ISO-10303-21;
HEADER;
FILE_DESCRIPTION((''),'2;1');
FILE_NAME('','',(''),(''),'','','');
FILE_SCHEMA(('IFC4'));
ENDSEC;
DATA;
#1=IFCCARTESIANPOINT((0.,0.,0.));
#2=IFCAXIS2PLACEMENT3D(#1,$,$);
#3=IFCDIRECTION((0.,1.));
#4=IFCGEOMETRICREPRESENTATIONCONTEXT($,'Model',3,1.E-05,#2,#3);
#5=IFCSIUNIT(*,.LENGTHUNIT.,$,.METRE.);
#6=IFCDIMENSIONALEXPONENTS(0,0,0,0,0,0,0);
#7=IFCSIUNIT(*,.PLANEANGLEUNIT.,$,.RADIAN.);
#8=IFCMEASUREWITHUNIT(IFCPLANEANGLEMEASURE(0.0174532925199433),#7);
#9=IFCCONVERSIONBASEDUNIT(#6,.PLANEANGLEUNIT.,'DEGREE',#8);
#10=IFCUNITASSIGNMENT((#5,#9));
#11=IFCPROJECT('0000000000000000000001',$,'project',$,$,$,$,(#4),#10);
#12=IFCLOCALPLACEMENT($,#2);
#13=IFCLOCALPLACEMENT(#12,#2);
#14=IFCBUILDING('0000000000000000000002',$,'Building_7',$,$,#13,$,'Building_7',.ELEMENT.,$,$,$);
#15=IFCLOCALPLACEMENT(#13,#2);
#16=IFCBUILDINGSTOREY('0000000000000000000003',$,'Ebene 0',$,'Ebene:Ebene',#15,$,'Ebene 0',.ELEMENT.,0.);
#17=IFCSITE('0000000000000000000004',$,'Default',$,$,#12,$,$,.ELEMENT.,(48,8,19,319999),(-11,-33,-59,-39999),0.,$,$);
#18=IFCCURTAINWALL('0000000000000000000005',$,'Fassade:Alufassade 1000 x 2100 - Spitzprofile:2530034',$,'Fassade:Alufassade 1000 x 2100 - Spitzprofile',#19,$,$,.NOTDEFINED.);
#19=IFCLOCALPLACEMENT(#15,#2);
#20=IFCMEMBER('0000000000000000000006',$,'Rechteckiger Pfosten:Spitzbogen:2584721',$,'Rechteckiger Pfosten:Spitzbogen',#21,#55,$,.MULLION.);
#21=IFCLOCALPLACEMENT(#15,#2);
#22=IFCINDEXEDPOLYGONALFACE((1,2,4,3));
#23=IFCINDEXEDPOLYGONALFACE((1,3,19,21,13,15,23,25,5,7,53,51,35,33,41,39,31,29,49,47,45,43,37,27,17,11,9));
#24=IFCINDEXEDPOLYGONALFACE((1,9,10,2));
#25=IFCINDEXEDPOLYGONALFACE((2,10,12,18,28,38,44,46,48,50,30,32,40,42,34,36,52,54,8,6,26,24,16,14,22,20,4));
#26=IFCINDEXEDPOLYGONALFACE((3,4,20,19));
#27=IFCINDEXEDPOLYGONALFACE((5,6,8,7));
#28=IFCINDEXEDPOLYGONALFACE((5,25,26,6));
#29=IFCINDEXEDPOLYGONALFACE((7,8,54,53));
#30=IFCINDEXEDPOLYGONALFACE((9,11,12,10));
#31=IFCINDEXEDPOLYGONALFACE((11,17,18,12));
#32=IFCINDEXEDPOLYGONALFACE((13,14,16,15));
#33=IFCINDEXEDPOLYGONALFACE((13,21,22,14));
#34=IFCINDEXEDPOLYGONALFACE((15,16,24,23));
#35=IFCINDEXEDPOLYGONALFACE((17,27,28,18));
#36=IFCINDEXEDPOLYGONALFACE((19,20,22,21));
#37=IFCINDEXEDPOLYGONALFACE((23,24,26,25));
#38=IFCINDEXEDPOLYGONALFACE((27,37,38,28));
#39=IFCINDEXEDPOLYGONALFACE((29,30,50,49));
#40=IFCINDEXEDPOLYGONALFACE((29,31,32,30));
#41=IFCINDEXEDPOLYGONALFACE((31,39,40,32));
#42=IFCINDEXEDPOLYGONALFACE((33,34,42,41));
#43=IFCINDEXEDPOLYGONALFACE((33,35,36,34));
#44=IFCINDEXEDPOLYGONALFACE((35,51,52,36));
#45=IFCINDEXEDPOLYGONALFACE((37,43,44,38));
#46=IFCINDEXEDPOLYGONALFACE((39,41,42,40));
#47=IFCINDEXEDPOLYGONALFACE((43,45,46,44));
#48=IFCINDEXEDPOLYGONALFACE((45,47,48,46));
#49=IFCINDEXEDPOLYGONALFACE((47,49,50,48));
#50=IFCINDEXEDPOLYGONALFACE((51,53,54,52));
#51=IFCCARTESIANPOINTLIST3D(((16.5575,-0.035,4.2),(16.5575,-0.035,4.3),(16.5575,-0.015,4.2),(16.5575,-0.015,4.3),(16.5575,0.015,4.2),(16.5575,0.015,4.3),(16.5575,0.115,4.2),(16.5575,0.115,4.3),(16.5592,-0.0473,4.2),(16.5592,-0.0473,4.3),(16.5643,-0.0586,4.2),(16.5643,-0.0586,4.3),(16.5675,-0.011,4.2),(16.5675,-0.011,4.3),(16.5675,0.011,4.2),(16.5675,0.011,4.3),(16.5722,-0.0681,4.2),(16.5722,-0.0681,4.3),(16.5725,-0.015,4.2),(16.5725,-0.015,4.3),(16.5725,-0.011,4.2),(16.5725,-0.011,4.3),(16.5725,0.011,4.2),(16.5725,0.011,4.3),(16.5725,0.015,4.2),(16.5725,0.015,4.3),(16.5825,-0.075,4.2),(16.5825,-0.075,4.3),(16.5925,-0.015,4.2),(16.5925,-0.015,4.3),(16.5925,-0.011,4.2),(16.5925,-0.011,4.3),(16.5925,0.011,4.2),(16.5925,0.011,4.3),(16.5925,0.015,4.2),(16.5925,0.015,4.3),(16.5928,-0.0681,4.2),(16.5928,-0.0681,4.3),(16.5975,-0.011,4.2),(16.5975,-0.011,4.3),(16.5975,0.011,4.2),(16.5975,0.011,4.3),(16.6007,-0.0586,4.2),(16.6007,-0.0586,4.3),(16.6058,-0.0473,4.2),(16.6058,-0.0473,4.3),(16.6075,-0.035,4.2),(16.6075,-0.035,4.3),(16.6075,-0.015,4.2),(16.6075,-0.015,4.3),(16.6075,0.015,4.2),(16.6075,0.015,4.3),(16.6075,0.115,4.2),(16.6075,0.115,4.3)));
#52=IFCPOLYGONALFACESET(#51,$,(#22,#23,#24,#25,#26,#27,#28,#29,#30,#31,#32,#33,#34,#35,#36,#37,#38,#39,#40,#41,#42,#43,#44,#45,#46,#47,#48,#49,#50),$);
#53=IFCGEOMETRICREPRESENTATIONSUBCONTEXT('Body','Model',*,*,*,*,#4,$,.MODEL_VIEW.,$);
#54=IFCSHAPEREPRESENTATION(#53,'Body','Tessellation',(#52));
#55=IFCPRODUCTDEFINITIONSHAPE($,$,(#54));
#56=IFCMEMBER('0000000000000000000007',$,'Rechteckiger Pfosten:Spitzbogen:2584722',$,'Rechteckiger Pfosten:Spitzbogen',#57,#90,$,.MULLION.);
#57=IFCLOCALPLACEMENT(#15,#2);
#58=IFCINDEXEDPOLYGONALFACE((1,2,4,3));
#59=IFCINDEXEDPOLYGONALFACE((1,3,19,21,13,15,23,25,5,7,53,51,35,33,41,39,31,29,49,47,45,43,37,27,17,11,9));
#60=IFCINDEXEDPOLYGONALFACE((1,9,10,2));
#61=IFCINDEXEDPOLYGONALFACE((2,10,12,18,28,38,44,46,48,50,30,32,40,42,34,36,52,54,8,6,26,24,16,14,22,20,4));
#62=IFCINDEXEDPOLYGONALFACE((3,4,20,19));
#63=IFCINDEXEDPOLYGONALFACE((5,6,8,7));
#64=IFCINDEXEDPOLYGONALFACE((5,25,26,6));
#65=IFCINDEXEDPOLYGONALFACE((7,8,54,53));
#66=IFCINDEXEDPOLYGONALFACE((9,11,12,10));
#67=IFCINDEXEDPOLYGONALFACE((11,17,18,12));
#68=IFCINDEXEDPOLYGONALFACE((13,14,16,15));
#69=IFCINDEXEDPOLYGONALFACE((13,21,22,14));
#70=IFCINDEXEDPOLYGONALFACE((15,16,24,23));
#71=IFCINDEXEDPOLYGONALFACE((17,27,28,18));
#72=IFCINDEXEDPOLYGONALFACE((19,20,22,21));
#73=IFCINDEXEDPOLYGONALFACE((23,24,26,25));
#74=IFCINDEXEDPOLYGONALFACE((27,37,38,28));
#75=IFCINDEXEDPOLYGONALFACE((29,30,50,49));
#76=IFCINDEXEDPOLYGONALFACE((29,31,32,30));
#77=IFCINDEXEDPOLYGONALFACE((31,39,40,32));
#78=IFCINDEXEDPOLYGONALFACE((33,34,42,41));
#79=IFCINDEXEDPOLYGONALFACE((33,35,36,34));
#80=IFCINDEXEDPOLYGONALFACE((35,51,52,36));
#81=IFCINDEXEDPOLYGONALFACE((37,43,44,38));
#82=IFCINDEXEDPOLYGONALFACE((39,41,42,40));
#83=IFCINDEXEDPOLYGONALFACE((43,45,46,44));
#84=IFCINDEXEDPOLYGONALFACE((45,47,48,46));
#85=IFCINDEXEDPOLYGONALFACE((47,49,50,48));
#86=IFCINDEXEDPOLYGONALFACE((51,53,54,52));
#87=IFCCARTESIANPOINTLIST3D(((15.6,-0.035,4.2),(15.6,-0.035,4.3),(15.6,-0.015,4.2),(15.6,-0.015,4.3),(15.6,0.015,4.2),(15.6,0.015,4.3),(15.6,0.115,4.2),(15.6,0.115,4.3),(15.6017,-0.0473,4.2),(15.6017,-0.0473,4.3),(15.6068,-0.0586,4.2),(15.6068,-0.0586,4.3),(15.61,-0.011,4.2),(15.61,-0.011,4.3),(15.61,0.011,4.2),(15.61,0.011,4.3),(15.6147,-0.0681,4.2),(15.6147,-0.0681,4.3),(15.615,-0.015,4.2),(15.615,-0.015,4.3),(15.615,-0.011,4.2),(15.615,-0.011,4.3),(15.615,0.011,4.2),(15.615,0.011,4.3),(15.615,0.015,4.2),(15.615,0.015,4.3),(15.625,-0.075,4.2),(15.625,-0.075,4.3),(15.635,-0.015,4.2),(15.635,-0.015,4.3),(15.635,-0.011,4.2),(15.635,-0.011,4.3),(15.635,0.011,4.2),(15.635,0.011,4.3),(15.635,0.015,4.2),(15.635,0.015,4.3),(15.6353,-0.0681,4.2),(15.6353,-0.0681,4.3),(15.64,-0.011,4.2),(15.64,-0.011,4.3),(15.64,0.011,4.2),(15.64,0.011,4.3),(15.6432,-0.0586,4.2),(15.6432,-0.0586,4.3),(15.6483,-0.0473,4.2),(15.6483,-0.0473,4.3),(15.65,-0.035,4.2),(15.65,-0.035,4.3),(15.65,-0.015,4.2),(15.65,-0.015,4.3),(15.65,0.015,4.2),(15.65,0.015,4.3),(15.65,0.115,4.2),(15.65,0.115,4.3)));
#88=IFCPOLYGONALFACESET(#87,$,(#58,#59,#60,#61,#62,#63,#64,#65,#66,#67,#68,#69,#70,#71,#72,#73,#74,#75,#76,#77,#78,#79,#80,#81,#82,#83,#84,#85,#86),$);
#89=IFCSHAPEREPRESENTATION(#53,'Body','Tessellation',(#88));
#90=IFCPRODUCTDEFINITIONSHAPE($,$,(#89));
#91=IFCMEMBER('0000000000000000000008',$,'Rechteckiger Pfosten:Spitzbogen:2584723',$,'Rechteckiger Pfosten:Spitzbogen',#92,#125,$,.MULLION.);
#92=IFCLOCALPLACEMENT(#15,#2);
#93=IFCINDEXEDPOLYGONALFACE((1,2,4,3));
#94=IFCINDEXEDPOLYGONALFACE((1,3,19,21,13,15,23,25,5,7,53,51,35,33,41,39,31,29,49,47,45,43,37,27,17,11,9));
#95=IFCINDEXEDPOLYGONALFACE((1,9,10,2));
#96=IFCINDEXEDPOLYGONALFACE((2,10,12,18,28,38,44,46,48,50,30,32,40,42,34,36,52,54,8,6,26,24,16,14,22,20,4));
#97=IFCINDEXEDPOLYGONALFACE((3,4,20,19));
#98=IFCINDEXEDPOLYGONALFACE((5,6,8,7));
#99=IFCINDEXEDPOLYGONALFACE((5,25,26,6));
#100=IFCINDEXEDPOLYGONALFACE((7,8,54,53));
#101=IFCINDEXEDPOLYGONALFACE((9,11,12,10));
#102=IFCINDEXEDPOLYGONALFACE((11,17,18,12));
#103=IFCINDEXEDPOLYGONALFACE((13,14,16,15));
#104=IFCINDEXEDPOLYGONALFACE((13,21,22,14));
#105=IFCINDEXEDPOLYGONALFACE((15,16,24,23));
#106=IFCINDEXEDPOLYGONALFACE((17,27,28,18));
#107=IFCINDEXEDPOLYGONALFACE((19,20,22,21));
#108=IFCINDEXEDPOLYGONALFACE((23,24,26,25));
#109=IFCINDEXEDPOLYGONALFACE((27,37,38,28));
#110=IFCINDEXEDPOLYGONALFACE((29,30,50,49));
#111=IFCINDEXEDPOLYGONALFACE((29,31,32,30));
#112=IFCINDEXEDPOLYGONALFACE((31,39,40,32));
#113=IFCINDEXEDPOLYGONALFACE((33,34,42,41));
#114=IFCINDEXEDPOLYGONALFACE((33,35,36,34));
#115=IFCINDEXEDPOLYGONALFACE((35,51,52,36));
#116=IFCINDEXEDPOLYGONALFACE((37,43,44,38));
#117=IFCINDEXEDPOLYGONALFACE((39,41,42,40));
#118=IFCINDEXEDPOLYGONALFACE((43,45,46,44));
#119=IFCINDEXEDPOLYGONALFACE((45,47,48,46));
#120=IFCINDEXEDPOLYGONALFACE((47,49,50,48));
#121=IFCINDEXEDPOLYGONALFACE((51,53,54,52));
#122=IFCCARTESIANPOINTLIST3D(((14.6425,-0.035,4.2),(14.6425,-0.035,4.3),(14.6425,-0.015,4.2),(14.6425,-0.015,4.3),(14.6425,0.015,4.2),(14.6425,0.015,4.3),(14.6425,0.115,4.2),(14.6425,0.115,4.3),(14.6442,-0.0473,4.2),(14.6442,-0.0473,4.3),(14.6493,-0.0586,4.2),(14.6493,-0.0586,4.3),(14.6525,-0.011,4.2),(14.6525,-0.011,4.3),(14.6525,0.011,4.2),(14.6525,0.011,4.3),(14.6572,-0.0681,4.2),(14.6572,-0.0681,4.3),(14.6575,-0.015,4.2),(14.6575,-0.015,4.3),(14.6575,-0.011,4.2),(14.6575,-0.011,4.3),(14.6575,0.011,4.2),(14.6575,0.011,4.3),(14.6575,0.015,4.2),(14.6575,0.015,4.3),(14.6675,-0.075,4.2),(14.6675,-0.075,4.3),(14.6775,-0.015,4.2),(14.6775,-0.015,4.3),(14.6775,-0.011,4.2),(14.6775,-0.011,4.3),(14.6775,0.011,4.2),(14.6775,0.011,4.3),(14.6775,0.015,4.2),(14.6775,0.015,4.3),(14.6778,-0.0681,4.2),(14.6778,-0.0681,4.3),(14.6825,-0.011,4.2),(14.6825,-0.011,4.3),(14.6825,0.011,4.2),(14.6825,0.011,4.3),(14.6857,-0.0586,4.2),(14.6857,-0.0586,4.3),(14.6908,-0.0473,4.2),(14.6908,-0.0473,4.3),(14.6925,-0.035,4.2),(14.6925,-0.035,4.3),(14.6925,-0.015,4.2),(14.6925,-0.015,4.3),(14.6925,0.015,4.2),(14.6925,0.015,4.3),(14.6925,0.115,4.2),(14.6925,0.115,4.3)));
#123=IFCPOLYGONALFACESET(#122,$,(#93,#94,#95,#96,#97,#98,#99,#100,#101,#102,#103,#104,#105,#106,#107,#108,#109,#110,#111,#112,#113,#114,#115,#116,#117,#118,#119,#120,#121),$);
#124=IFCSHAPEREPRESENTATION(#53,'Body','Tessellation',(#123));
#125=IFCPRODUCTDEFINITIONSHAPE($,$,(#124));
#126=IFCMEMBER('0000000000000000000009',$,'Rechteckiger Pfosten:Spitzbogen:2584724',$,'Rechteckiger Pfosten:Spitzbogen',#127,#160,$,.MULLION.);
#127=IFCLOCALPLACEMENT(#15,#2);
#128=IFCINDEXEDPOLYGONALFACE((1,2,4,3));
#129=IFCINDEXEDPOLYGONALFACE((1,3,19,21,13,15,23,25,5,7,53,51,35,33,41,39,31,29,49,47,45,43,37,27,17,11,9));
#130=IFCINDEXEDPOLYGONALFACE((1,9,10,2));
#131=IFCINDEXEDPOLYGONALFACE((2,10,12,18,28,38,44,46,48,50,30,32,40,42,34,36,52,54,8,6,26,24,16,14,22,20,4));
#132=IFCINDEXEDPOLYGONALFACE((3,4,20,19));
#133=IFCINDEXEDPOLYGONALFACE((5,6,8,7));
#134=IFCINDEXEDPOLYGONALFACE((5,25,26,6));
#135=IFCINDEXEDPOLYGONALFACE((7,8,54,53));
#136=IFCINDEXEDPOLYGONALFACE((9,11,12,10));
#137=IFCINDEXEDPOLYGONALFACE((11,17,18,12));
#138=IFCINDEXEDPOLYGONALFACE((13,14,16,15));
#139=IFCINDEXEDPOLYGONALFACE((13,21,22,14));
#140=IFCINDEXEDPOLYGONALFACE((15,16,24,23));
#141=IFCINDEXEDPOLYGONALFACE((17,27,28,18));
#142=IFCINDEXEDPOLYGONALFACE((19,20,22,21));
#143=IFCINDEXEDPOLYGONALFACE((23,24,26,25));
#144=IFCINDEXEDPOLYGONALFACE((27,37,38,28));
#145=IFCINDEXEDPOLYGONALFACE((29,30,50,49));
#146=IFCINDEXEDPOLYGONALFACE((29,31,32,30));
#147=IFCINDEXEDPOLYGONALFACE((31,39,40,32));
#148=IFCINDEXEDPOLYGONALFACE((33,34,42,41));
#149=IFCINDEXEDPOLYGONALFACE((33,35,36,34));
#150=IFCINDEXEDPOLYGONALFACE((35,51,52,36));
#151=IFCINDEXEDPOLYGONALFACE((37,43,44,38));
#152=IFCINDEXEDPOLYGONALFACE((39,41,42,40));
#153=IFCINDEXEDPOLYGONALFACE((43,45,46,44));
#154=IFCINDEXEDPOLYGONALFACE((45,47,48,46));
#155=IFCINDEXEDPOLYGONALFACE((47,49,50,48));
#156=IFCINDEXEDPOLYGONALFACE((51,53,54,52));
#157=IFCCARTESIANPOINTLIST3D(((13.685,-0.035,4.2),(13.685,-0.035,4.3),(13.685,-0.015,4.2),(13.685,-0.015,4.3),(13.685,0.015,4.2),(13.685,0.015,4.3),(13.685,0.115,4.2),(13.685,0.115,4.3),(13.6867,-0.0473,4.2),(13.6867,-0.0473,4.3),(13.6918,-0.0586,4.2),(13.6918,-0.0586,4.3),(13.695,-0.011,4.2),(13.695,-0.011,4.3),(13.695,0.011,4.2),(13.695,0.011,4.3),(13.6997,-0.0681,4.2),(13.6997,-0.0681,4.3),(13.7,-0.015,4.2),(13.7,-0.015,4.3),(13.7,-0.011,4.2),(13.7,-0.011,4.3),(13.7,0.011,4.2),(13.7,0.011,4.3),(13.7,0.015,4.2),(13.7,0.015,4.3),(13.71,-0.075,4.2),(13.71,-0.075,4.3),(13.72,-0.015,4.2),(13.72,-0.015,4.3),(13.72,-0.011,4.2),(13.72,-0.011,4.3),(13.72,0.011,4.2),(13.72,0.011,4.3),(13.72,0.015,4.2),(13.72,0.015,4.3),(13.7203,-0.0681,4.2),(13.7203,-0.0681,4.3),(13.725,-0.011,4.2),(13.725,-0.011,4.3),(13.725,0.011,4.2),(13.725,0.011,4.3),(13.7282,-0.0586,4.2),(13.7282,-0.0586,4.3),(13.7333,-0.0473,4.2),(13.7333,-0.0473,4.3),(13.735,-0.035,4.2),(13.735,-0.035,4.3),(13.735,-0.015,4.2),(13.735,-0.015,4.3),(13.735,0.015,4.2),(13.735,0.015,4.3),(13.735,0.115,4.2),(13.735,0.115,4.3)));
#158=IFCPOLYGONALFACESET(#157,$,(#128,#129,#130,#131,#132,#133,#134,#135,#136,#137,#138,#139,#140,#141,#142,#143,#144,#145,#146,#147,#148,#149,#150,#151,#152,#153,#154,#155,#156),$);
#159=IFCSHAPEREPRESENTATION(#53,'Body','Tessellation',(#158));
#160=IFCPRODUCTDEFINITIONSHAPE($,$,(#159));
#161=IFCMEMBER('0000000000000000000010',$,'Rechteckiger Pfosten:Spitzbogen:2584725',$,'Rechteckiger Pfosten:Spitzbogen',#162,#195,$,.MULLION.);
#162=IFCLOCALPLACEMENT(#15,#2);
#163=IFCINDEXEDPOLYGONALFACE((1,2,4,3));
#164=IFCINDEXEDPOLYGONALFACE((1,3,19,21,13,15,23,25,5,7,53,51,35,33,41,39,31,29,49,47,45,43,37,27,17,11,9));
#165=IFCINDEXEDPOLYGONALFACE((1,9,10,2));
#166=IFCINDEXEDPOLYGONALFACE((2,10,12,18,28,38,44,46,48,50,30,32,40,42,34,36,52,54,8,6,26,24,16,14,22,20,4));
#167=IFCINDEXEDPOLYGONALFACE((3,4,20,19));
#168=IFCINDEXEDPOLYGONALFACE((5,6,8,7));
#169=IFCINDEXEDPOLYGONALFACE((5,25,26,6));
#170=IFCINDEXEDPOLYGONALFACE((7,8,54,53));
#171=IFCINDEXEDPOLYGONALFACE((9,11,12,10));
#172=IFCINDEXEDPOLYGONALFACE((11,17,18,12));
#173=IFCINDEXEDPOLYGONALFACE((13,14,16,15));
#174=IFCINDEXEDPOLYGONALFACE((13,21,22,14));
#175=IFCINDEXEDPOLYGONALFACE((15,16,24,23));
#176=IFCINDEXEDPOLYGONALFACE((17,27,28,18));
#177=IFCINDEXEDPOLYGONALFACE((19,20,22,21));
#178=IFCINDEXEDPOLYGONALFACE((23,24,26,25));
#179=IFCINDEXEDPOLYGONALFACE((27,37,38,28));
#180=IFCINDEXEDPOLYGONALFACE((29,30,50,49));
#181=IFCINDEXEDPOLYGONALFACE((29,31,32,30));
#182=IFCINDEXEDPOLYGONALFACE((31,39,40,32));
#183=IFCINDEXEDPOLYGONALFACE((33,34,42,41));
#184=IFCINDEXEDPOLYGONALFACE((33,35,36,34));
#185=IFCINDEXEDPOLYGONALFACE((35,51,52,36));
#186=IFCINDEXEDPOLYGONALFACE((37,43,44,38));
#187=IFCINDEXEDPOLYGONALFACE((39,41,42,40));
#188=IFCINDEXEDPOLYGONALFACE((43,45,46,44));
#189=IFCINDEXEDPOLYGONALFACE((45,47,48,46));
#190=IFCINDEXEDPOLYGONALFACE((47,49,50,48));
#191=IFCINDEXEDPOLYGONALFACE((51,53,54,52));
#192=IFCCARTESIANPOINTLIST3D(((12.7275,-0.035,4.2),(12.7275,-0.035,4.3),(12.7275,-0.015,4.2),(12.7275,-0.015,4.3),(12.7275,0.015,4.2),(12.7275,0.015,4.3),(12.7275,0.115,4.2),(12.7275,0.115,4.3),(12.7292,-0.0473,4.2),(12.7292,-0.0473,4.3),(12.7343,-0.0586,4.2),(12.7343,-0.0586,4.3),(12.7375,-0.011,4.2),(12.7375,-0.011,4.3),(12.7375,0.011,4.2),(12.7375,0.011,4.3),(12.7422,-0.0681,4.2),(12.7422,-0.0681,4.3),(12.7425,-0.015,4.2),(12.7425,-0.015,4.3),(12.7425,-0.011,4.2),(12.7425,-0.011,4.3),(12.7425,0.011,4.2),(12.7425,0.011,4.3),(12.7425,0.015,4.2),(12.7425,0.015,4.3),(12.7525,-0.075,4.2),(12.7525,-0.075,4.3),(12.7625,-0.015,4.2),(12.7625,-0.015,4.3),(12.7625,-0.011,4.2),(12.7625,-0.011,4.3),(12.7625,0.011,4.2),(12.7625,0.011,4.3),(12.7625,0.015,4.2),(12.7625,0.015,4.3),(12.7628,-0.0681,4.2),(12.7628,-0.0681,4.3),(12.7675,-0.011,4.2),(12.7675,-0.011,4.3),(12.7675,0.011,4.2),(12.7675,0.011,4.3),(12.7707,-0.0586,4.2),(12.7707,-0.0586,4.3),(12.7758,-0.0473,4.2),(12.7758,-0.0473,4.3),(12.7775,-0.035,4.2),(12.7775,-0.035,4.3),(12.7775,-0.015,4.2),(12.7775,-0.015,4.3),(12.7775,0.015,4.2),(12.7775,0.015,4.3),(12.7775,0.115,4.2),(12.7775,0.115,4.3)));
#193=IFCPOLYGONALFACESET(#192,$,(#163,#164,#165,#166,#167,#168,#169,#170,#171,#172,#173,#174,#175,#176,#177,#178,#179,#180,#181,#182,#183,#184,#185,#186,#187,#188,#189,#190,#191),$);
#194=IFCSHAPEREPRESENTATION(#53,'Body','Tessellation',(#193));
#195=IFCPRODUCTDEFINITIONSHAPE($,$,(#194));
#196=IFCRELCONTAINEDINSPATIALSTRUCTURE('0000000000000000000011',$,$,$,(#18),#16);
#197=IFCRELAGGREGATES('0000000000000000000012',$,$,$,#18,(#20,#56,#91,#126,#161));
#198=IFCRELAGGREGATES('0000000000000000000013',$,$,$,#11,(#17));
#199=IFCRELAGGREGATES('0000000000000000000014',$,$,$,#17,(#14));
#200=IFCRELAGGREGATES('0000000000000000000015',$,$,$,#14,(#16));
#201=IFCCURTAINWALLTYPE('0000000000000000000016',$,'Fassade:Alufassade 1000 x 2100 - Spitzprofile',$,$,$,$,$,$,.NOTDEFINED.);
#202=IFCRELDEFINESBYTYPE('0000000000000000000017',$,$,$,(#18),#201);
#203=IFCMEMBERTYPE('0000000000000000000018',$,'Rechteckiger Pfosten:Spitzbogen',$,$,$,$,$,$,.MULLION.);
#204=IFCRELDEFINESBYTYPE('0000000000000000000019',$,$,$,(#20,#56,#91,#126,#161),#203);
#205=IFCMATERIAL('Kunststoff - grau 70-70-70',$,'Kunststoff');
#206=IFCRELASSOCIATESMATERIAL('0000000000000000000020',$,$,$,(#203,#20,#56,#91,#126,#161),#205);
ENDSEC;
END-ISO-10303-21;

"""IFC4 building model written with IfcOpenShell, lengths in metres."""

from ifc_helpers import new_model, entity, si_unit, converted_unit, direction, frame, origin, place, context, subcontext, project, spatial, line, arc, indexed_curve, outline, extrude, source, transform, mapped, material, type_object, type_shapes, element, aggregate, save


model = new_model("IFC4")

# Units and contexts
model_context = context("Model", 3, precision=1e-05, world=origin(), true_north=direction((0.0, 1.0)))
body_context = subcontext(model_context, "Body", "Model", "MODEL_VIEW")
ifc_project = project(units=[si_unit("LENGTHUNIT", "METRE"), converted_unit("PLANEANGLEUNIT", "DEGREE", entity("IfcPlaneAngleMeasure", 0.0174532925199433), si_unit("PLANEANGLEUNIT", "RADIAN"), dimensions=[0, 0, 0, 0, 0, 0, 0])], contexts=[model_context])

# Site, building, storey
site_placement = place(None, origin())
site = spatial("IfcSite", under=ifc_project, at=site_placement, Name="Default", CompositionType="ELEMENT", RefLatitude=(48, 8, 19, 319999), RefLongitude=(-11, -33, -59, -39999), RefElevation=0.0)
building_placement = place(site_placement, origin())
building = spatial("IfcBuilding", under=site, at=building_placement, Name="Building_7", LongName="Building_7", CompositionType="ELEMENT")
storey_placement = place(building_placement, origin())
storey = spatial("IfcBuildingStorey", under=building, at=storey_placement, Name="Ebene 0", ObjectType="Ebene:Ebene", LongName="Ebene 0", CompositionType="ELEMENT", Elevation=0.0)

# Curtain wall, members
curtain_wall_type = type_object("IfcCurtainWallType", Name="Fassade:Alufassade 1000 x 2100 - Spitzprofile", PredefinedType="NOTDEFINED")
curtain_wall_placement = place(storey_placement, origin())
curtain_wall = element("IfcCurtainWall", 1, at=curtain_wall_placement, inside=storey, type_object=curtain_wall_type, Name="Fassade:Alufassade 1000 x 2100 - Spitzprofile:2530034", ObjectType="Fassade:Alufassade 1000 x 2100 - Spitzprofile", PredefinedType="NOTDEFINED")
ifc_material = material(Name="Kunststoff - grau 70-70-70", Category="Kunststoff")
member_type_1 = type_object("IfcMemberType", Name="Rechteckiger Pfosten:Spitzbogen", PredefinedType="MULLION", material=ifc_material)
shared_shape_1 = source(origin(), body_context, "Body", "SweptSolid", [
    extrude(outline(indexed_curve([(-0.111, -0.025), (-0.011, -0.025), (-0.011, -0.01), (-0.007, -0.01), (-0.007, -0.015), (0.015, -0.015), (0.015, -0.01), (0.019, -0.01), (0.019, -0.025), (0.039, -0.025), (0.0626, -0.0182), (0.079, 0.0), (0.0626, 0.0182), (0.039, 0.025), (0.019, 0.025), (0.019, 0.01), (0.015, 0.01), (0.015, 0.015), (-0.007, 0.015), (-0.007, 0.01), (-0.011, 0.01), (-0.011, 0.025), (-0.111, 0.025)], segments=[line(1, 2, 3, 4, 5, 6, 7, 8, 9, 10), arc(10, 11, 12), arc(12, 13, 14), line(14, 15, 16, 17, 18, 19, 20, 21, 22, 23, 1)], self_intersect=False)), frame((0.0, 0.004, -0.1), z_axis=(0.0, 0.0, 1.0), x_axis=(0.0, -1.0, 0.0)), (0.0, 0.0, 1.0), 0.1),
])
type_shapes(member_type_1, [shared_shape_1])
member_1_placement = place(curtain_wall_placement, frame((16.5825, 0.0, 4.2), z_axis=(0.0, 0.0, -1.0), x_axis=(-1.0, 0.0, 0.0)))
member_1 = element("IfcMember", 2, at=member_1_placement, type_object=member_type_1, material=ifc_material, Name="Rechteckiger Pfosten:Spitzbogen:2584721", ObjectType="Rechteckiger Pfosten:Spitzbogen", PredefinedType="MULLION", context=body_context, shape_type="MappedRepresentation", body=[
    mapped(shared_shape_1, transform((0.0, 0.0, 0.0), scale=1.0)),
])
member_2_placement = place(curtain_wall_placement, frame((15.625, 0.0, 4.2), z_axis=(0.0, 0.0, -1.0), x_axis=(-1.0, 0.0, 0.0)))
member_2 = element("IfcMember", 3, at=member_2_placement, type_object=member_type_1, material=ifc_material, Name="Rechteckiger Pfosten:Spitzbogen:2584722", ObjectType="Rechteckiger Pfosten:Spitzbogen", PredefinedType="MULLION", context=body_context, shape_type="MappedRepresentation", body=[
    mapped(shared_shape_1, transform((0.0, 0.0, 0.0), scale=1.0)),
])
member_3_placement = place(curtain_wall_placement, frame((14.6675, 0.0, 4.2), z_axis=(0.0, 0.0, -1.0), x_axis=(-1.0, 0.0, 0.0)))
member_3 = element("IfcMember", 4, at=member_3_placement, type_object=member_type_1, material=ifc_material, Name="Rechteckiger Pfosten:Spitzbogen:2584723", ObjectType="Rechteckiger Pfosten:Spitzbogen", PredefinedType="MULLION", context=body_context, shape_type="MappedRepresentation", body=[
    mapped(shared_shape_1, transform((0.0, 0.0, 0.0), scale=1.0)),
])
member_4_placement = place(curtain_wall_placement, frame((13.71, 0.0, 4.2), z_axis=(0.0, 0.0, -1.0), x_axis=(-1.0, 0.0, 0.0)))
member_4 = element("IfcMember", 5, at=member_4_placement, type_object=member_type_1, material=ifc_material, Name="Rechteckiger Pfosten:Spitzbogen:2584724", ObjectType="Rechteckiger Pfosten:Spitzbogen", PredefinedType="MULLION", context=body_context, shape_type="MappedRepresentation", body=[
    mapped(shared_shape_1, transform((0.0, 0.0, 0.0), scale=1.0)),
])
member_5_placement = place(curtain_wall_placement, frame((12.7525, 0.0, 4.2), z_axis=(0.0, 0.0, -1.0), x_axis=(-1.0, 0.0, 0.0)))
member_5 = element("IfcMember", 6, at=member_5_placement, type_object=member_type_1, material=ifc_material, Name="Rechteckiger Pfosten:Spitzbogen:2584725", ObjectType="Rechteckiger Pfosten:Spitzbogen", PredefinedType="MULLION", context=body_context, shape_type="MappedRepresentation", body=[
    mapped(shared_shape_1, transform((0.0, 0.0, 0.0), scale=1.0)),
])
aggregate(curtain_wall, [member_1, member_2, member_3, member_4, member_5])

save(model, "model.ifc")
